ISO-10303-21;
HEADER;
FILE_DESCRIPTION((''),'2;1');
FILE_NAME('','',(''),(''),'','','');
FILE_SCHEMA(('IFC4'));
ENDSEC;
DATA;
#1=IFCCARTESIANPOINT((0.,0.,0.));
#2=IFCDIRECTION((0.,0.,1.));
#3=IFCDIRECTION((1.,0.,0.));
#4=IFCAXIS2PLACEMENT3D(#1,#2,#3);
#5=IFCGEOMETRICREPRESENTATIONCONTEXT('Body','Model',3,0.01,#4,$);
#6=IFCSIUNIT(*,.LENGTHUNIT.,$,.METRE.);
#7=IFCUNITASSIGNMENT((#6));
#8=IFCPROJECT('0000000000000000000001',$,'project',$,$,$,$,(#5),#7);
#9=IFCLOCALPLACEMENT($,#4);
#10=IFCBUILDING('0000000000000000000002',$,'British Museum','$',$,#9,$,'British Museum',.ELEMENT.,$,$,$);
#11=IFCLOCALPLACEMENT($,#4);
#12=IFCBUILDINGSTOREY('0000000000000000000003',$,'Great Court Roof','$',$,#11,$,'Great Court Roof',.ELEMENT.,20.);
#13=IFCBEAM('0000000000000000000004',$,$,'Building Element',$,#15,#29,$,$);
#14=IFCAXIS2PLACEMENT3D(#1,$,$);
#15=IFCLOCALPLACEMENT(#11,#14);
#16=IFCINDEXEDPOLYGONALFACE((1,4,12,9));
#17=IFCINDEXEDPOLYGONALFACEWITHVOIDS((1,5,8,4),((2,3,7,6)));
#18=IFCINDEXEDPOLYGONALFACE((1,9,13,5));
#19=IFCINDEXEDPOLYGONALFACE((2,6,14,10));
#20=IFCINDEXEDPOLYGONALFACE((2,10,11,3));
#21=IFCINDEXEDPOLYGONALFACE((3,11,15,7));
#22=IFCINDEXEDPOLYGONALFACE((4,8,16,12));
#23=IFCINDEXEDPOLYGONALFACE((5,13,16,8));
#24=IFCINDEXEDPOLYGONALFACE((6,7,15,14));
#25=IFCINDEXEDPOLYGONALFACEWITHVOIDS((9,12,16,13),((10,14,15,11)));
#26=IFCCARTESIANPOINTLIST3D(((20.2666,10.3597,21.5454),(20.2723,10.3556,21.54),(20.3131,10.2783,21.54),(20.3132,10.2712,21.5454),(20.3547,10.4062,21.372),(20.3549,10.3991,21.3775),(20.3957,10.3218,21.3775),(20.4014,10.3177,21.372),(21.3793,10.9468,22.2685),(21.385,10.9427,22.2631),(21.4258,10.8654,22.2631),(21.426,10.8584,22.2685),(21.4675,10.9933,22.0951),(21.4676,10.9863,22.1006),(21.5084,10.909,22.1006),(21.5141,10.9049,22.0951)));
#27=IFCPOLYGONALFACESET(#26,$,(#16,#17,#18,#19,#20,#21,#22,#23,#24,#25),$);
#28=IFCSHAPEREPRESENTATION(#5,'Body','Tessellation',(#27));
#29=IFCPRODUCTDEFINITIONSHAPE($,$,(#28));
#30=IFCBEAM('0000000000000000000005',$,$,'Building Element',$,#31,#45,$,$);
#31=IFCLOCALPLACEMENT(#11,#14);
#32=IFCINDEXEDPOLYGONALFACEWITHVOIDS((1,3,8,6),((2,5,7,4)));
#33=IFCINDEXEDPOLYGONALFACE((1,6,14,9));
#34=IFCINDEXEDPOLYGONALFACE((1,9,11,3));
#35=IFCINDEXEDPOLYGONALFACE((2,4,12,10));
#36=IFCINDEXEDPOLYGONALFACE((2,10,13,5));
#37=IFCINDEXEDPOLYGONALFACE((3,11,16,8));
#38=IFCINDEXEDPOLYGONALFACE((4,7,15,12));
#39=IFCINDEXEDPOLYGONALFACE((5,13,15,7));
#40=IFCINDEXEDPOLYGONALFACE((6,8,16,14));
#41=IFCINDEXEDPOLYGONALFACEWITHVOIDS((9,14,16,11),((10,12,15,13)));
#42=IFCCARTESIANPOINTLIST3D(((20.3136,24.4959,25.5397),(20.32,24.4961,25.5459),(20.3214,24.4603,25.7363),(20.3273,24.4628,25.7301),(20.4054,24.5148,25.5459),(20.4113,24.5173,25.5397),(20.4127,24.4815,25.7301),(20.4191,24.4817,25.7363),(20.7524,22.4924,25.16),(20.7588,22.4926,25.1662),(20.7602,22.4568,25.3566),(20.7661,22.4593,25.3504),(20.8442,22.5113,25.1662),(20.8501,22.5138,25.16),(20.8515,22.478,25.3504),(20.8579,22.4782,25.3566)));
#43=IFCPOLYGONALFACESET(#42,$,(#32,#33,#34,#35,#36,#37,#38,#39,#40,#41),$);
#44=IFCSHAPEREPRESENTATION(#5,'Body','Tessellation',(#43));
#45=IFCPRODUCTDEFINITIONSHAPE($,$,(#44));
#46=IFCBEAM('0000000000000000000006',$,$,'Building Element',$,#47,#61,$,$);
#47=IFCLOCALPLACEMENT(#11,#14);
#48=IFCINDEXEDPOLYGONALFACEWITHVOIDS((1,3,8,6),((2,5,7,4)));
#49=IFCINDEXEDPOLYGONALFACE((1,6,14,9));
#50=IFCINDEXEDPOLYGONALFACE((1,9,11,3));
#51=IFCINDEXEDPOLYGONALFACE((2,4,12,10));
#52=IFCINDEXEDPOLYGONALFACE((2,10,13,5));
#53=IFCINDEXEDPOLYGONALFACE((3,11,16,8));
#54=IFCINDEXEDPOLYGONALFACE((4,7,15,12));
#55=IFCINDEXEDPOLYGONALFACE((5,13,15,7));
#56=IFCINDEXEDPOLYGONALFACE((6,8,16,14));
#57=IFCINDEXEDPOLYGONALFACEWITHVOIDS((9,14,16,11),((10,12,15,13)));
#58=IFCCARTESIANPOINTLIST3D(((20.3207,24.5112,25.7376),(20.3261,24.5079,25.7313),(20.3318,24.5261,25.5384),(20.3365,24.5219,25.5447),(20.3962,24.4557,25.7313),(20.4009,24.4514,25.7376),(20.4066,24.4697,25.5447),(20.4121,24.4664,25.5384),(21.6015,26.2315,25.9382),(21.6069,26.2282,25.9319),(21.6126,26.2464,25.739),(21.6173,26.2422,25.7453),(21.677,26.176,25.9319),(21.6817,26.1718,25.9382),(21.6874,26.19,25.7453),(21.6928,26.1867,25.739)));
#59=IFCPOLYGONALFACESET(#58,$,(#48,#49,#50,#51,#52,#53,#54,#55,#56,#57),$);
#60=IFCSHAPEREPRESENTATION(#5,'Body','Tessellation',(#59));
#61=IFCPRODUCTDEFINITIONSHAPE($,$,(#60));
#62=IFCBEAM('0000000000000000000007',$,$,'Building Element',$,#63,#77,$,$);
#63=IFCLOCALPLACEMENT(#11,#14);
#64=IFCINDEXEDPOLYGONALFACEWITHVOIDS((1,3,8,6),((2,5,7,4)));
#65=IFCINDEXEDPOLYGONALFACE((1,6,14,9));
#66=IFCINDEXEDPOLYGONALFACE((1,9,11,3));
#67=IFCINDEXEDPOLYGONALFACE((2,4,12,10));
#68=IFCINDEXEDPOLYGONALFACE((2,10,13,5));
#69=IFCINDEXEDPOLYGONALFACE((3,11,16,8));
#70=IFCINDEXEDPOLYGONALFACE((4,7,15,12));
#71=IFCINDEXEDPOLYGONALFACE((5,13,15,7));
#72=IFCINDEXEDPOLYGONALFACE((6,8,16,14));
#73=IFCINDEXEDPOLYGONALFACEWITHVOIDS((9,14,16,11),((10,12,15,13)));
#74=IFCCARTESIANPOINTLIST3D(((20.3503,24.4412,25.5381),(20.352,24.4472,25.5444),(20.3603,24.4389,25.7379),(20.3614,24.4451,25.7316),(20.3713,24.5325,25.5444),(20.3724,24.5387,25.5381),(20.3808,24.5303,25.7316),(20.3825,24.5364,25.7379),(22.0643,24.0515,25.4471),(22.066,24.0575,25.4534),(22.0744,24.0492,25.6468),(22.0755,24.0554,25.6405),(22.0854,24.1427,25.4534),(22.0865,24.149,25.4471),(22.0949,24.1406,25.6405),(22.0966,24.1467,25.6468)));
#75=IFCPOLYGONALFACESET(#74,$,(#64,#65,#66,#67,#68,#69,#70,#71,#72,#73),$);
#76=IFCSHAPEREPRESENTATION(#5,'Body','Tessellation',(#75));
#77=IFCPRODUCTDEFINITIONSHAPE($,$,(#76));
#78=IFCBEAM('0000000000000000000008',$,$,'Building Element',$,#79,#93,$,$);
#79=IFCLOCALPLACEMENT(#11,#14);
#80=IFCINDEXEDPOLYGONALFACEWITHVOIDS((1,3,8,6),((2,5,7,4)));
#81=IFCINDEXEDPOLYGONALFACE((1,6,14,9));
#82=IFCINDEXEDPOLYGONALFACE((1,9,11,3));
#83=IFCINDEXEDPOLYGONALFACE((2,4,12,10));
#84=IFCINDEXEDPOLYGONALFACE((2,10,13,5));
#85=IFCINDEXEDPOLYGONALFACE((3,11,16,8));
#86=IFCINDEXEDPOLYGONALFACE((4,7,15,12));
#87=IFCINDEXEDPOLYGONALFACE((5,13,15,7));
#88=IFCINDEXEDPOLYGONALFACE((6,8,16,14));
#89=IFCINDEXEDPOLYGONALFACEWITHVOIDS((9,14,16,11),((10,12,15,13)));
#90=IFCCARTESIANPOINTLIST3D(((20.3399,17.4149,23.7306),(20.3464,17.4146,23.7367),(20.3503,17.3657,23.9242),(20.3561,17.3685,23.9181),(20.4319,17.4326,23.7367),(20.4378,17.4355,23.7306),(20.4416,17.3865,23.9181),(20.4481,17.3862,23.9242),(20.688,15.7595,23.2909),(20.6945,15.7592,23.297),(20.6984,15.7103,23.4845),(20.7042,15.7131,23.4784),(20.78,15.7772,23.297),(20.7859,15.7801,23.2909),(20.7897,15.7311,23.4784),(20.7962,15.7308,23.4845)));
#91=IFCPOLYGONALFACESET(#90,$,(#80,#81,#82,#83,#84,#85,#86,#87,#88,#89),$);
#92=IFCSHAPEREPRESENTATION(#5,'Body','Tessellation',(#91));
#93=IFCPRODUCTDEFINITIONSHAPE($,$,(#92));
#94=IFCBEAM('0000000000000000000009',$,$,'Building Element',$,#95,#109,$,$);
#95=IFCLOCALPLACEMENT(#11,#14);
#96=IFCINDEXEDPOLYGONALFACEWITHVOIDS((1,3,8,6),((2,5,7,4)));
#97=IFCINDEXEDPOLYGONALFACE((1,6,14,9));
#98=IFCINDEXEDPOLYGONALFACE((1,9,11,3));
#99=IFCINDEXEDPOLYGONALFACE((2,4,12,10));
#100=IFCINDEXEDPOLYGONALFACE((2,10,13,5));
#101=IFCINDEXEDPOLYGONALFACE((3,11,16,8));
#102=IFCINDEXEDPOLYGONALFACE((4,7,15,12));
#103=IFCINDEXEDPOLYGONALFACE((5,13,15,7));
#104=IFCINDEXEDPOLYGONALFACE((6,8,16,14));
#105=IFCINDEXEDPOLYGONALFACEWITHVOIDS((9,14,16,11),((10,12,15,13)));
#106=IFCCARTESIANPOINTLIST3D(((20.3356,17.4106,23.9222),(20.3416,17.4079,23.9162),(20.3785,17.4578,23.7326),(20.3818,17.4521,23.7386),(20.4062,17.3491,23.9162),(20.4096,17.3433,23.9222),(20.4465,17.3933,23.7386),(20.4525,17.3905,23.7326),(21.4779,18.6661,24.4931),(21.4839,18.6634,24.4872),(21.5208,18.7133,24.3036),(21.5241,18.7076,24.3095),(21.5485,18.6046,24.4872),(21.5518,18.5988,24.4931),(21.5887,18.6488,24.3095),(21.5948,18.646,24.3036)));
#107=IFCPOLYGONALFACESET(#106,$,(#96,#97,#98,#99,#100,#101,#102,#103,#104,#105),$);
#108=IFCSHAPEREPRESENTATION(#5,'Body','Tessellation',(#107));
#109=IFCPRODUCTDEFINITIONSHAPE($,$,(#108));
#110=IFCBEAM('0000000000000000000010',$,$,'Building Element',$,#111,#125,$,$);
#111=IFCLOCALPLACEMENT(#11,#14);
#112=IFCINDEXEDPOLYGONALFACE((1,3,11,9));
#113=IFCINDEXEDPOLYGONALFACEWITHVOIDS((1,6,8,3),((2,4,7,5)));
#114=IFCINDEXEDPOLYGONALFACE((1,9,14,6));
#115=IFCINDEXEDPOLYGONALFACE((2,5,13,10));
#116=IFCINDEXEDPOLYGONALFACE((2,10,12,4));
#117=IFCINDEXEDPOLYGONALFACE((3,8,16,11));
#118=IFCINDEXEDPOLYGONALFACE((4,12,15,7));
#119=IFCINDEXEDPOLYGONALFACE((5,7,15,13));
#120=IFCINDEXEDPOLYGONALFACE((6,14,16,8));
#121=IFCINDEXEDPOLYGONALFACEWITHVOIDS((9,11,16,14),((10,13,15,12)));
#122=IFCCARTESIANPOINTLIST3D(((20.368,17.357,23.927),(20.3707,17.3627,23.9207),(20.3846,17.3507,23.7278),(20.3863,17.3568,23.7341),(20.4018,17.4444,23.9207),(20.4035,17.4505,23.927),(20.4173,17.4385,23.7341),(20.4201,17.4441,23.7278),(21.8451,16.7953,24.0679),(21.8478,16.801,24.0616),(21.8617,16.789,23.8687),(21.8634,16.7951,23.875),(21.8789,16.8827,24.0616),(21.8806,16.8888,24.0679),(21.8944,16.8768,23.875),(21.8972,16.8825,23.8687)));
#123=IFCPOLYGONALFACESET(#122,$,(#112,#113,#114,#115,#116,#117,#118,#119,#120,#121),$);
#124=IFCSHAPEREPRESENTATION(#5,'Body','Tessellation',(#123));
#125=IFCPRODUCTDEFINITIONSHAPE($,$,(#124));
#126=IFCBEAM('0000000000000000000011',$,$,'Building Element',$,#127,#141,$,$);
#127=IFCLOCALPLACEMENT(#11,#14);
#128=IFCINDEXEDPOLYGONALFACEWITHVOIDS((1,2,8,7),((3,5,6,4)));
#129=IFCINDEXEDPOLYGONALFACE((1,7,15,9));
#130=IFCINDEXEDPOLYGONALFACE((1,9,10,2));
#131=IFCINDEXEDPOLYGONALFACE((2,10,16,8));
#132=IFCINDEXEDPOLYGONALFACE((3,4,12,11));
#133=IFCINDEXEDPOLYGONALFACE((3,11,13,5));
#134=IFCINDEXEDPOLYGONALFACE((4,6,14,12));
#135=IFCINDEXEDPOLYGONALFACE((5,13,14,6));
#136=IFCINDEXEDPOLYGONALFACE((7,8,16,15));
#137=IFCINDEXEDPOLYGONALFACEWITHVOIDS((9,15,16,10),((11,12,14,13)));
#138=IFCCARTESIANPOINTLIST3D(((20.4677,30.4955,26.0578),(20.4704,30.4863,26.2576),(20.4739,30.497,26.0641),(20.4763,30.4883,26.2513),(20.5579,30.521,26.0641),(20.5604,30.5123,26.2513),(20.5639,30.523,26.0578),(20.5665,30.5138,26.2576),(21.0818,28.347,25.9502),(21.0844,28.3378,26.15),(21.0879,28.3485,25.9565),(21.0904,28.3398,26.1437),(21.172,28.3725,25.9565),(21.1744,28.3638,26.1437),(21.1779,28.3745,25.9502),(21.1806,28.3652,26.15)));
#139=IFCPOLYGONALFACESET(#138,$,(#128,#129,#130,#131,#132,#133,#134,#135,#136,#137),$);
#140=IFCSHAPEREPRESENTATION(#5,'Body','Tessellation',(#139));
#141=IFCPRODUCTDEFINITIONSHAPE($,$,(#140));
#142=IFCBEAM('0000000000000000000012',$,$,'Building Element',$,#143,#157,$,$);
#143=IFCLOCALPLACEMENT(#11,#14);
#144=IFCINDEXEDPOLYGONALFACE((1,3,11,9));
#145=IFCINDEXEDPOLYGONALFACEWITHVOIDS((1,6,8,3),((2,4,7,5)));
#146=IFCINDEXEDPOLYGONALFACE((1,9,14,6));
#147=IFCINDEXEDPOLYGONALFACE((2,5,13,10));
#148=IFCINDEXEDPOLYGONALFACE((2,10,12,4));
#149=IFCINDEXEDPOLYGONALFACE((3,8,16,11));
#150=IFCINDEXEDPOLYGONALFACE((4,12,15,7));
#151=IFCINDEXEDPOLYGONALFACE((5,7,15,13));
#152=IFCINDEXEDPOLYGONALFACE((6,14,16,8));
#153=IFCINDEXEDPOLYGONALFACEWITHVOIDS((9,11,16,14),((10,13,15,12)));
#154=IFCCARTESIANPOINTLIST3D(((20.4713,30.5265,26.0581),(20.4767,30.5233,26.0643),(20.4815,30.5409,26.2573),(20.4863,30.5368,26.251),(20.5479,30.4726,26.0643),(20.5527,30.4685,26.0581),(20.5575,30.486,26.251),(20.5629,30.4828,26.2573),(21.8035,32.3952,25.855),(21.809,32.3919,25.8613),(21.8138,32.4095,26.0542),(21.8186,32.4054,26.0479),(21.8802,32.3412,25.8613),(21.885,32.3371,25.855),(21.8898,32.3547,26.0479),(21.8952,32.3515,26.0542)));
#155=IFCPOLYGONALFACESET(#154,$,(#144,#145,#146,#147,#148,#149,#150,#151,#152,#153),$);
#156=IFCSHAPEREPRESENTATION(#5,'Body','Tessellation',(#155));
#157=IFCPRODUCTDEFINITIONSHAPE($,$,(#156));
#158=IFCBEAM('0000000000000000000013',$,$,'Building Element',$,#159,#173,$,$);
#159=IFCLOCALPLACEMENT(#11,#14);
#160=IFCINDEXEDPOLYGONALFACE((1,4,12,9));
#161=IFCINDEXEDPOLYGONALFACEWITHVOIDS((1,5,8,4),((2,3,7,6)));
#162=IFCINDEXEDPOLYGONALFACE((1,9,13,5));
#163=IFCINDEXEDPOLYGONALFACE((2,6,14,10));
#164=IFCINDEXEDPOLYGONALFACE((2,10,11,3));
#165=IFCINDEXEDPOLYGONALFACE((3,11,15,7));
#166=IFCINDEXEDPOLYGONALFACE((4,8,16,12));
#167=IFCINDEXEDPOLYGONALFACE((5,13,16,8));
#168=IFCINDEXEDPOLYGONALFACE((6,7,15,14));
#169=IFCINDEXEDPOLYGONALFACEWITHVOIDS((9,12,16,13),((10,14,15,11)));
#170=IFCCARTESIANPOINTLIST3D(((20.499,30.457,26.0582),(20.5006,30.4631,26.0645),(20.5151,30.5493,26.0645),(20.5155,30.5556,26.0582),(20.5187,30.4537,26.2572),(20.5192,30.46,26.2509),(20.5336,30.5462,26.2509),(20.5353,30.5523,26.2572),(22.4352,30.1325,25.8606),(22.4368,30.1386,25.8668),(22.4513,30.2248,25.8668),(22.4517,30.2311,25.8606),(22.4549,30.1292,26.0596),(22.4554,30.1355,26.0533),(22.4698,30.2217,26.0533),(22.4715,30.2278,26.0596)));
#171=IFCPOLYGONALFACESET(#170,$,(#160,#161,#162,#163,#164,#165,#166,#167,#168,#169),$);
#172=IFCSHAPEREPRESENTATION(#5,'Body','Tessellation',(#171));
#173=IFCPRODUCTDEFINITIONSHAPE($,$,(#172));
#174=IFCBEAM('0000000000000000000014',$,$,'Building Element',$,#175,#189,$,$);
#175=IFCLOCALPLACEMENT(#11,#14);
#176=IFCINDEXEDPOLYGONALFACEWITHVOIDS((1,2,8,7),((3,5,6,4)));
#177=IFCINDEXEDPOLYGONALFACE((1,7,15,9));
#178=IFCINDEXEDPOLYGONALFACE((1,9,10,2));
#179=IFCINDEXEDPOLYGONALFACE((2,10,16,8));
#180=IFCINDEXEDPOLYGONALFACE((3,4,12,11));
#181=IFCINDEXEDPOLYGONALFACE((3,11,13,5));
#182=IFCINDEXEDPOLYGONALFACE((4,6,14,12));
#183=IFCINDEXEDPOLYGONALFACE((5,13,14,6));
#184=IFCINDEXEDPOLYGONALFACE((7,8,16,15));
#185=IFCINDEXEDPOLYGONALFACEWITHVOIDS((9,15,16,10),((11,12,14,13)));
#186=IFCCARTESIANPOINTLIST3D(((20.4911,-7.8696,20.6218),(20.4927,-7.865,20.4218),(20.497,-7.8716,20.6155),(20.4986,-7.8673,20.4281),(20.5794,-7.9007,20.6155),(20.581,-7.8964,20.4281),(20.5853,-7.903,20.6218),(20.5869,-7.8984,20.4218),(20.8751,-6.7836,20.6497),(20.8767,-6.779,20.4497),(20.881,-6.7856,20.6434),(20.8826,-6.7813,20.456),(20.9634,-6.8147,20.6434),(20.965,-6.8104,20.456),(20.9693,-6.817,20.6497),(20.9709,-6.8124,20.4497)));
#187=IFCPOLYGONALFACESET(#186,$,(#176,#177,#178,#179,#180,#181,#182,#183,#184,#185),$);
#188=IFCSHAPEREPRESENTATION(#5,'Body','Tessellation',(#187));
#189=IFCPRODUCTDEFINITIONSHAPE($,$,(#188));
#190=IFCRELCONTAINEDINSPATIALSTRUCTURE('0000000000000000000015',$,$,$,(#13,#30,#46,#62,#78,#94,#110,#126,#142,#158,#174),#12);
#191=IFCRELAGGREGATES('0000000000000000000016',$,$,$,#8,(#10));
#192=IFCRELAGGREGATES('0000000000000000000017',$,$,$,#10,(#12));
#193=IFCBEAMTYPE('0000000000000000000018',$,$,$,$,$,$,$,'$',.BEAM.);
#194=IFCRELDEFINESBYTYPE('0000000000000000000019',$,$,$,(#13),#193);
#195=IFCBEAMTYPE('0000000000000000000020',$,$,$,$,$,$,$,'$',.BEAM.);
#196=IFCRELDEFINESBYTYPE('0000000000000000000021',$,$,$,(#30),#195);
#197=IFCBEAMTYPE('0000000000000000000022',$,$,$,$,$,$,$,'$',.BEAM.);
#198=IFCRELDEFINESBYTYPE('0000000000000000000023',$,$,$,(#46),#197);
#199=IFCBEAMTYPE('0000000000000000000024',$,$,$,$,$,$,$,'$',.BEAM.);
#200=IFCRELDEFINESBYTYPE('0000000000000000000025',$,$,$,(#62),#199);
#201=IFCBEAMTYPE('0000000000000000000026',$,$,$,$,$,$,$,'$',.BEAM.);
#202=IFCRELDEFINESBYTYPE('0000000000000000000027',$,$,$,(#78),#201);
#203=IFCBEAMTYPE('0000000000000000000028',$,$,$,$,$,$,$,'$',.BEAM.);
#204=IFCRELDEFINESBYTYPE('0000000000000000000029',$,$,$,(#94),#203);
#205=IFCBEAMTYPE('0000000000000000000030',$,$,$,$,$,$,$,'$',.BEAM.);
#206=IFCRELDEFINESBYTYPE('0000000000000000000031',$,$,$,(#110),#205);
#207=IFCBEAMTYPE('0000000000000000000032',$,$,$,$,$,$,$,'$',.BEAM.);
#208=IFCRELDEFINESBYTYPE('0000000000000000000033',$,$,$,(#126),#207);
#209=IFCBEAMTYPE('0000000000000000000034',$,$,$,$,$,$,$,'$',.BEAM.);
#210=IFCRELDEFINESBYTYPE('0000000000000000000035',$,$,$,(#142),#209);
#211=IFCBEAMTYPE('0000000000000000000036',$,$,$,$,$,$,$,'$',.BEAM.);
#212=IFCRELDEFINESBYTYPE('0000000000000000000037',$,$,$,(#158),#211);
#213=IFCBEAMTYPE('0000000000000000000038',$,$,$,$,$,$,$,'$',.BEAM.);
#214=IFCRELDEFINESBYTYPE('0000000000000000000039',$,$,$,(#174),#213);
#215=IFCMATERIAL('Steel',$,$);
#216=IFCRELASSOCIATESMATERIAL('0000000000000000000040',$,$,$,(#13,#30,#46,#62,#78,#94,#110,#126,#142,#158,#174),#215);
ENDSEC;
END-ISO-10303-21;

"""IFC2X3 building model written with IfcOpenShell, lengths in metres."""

from ifc_helpers import new_model, si_unit, frame, origin_with_axes, origin_2d, place, context, project, spatial, hollow_rectangle, extrude, material, type_object, element, save


model = new_model("IFC2X3")

# Units and contexts
model_context = context("Model", 3, precision=0.01, world=origin_with_axes(), identifier="Body")
ifc_project = project(units=[si_unit("LENGTHUNIT", "METRE")], contexts=[model_context])

# Building, storey
building_placement = place(None, origin_with_axes())
building = spatial("IfcBuilding", under=ifc_project, at=building_placement, Name="British Museum", Description="$", LongName="British Museum", CompositionType="ELEMENT")
storey_placement = place(None, origin_with_axes())
storey = spatial("IfcBuildingStorey", under=building, at=storey_placement, Name="Great Court Roof", Description="$", LongName="Great Court Roof", CompositionType="ELEMENT", Elevation=20.0)

# Beams
ifc_material = material(Name="Steel")
beam_type_1 = type_object("IfcBeamType", ElementType="$", PredefinedType="BEAM")
beam_1_placement = place(None, origin_with_axes())
element("IfcBeam", 1, at=beam_1_placement, inside=storey, type_object=beam_type_1, material=ifc_material, Description="Building Element", context=model_context, shape_type="SweptSolid", body=[
    extrude(hollow_rectangle(XDim=0.1, YDim=0.2, WallThickness=0.0063, InnerFilletRadius=0.0, OuterFilletRadius=0.0, at=origin_2d()), frame((20.334, 10.3387, 21.4587), z_axis=(0.766806, 0.404609, 0.498297), x_axis=(-0.466673, 0.88443, 0.0)), (0.0, 0.0, 1.0), 1.4512),
])
beam_type_2 = type_object("IfcBeamType", ElementType="$", PredefinedType="BEAM")
beam_2_placement = place(None, origin_with_axes())
element("IfcBeam", 2, at=beam_2_placement, inside=storey, type_object=beam_type_2, material=ifc_material, Description="Building Element", context=model_context, shape_type="SweptSolid", body=[
    extrude(hollow_rectangle(XDim=0.1, YDim=0.2, WallThickness=0.0063, InnerFilletRadius=0.0, OuterFilletRadius=0.0, at=origin_2d()), frame((20.3664, 24.4888, 25.638), z_axis=(0.210363, -0.960524, -0.182045), x_axis=(0.976847, 0.213937, 0.0)), (0.0, 0.0, 1.0), 2.0858),
])
beam_type_3 = type_object("IfcBeamType", ElementType="$", PredefinedType="BEAM")
beam_3_placement = place(None, origin_with_axes())
element("IfcBeam", 3, at=beam_3_placement, inside=storey, type_object=beam_type_3, material=ifc_material, Description="Building Element", context=model_context, shape_type="SweptSolid", body=[
    extrude(hollow_rectangle(XDim=0.1, YDim=0.2, WallThickness=0.0063, InnerFilletRadius=0.0, OuterFilletRadius=0.0, at=origin_2d()), frame((20.3664, 24.4888, 25.638), z_axis=(0.594578, 0.798628, 0.093118), x_axis=(-0.802113, 0.597172, 0.0)), (0.0, 0.0, 1.0), 2.1541),
])
beam_type_4 = type_object("IfcBeamType", ElementType="$", PredefinedType="BEAM")
beam_4_placement = place(None, origin_with_axes())
element("IfcBeam", 4, at=beam_4_placement, inside=storey, type_object=beam_type_4, material=ifc_material, Description="Building Element", context=model_context, shape_type="SweptSolid", body=[
    extrude(hollow_rectangle(XDim=0.1, YDim=0.2, WallThickness=0.0063, InnerFilletRadius=0.0, OuterFilletRadius=0.0, at=origin_2d()), frame((20.3664, 24.4888, 25.638), z_axis=(0.973809, -0.221406, -0.051723), x_axis=(0.221702, 0.975114, 0.0)), (0.0, 0.0, 1.0), 1.7602),
])
beam_type_5 = type_object("IfcBeamType", ElementType="$", PredefinedType="BEAM")
beam_5_placement = place(None, origin_with_axes())
element("IfcBeam", 5, at=beam_5_placement, inside=storey, type_object=beam_type_5, material=ifc_material, Description="Building Element", context=model_context, shape_type="SweptSolid", body=[
    extrude(hollow_rectangle(XDim=0.1, YDim=0.2, WallThickness=0.0063, InnerFilletRadius=0.0, OuterFilletRadius=0.0, at=origin_2d()), frame((20.394, 17.4006, 23.8274), z_axis=(0.199159, -0.94713, -0.251556), x_axis=(0.978599, 0.205776, 0.0)), (0.0, 0.0, 1.0), 1.7478),
])
beam_type_6 = type_object("IfcBeamType", ElementType="$", PredefinedType="BEAM")
beam_6_placement = place(None, origin_with_axes())
element("IfcBeam", 6, at=beam_6_placement, inside=storey, type_object=beam_type_6, material=ifc_material, Description="Building Element", context=model_context, shape_type="SweptSolid", body=[
    extrude(hollow_rectangle(XDim=0.1, YDim=0.2, WallThickness=0.0063, InnerFilletRadius=0.0, OuterFilletRadius=0.0, at=origin_2d()), frame((20.394, 17.4006, 23.8274), z_axis=(0.637854, 0.701069, 0.318818), x_axis=(-0.739668, 0.672972, 0.0)), (0.0, 0.0, 1.0), 1.7908),
])
beam_type_7 = type_object("IfcBeamType", ElementType="$", PredefinedType="BEAM")
beam_7_placement = place(None, origin_with_axes())
element("IfcBeam", 7, at=beam_7_placement, inside=storey, type_object=beam_type_7, material=ifc_material, Description="Building Element", context=model_context, shape_type="SweptSolid", body=[
    extrude(hollow_rectangle(XDim=0.1, YDim=0.2, WallThickness=0.0063, InnerFilletRadius=0.0, OuterFilletRadius=0.0, at=origin_2d()), frame((20.394, 17.4006, 23.8274), z_axis=(0.931013, -0.354017, 0.088809), x_axis=(0.355421, 0.934706, 0.0)), (0.0, 0.0, 1.0), 1.5866),
])
beam_type_8 = type_object("IfcBeamType", ElementType="$", PredefinedType="BEAM")
beam_8_placement = place(None, origin_with_axes())
element("IfcBeam", 8, at=beam_8_placement, inside=storey, type_object=beam_type_8, material=ifc_material, Description="Building Element", context=model_context, shape_type="SweptSolid", body=[
    extrude(hollow_rectangle(XDim=0.1, YDim=0.2, WallThickness=0.0063, InnerFilletRadius=0.0, OuterFilletRadius=0.0, at=origin_2d()), frame((20.5171, 30.5047, 26.1577), z_axis=(0.274483, -0.960389, -0.048092), x_axis=(0.961501, 0.274801, 0.0)), (0.0, 0.0, 1.0), 2.2371),
])
beam_type_9 = type_object("IfcBeamType", ElementType="$", PredefinedType="BEAM")
beam_9_placement = place(None, origin_with_axes())
element("IfcBeam", 9, at=beam_9_placement, inside=storey, type_object=beam_type_9, material=ifc_material, Description="Building Element", context=model_context, shape_type="SweptSolid", body=[
    extrude(hollow_rectangle(XDim=0.1, YDim=0.2, WallThickness=0.0063, InnerFilletRadius=0.0, OuterFilletRadius=0.0, at=origin_2d()), frame((20.5171, 30.5047, 26.1577), z_axis=(0.57826, 0.811077, -0.088145), x_axis=(-0.814246, 0.58052, 0.0)), (0.0, 0.0, 1.0), 2.3039),
])
beam_type_10 = type_object("IfcBeamType", ElementType="$", PredefinedType="BEAM")
beam_10_placement = place(None, origin_with_axes())
element("IfcBeam", 10, at=beam_10_placement, inside=storey, type_object=beam_type_10, material=ifc_material, Description="Building Element", context=model_context, shape_type="SweptSolid", body=[
    extrude(hollow_rectangle(XDim=0.1, YDim=0.2, WallThickness=0.0063, InnerFilletRadius=0.0, OuterFilletRadius=0.0, at=origin_2d()), frame((20.5171, 30.5047, 26.1577), z_axis=(0.981286, -0.164457, -0.100156), x_axis=(0.165288, 0.986245, 0.0)), (0.0, 0.0, 1.0), 1.9731),
])
beam_type_11 = type_object("IfcBeamType", ElementType="$", PredefinedType="BEAM")
beam_11_placement = place(None, origin_with_axes())
element("IfcBeam", 11, at=beam_11_placement, inside=storey, type_object=beam_type_11, material=ifc_material, Description="Building Element", context=model_context, shape_type="SweptSolid", body=[
    extrude(hollow_rectangle(XDim=0.1, YDim=0.2, WallThickness=0.0063, InnerFilletRadius=0.0, OuterFilletRadius=0.0, at=origin_2d()), frame((20.539, -7.884, 20.5218), z_axis=(0.333267, 0.942521, 0.024217), x_axis=(-0.942798, 0.333365, 0.0)), (0.0, 0.0, 1.0), 1.1522),
])

save(model, "model.ifc")
